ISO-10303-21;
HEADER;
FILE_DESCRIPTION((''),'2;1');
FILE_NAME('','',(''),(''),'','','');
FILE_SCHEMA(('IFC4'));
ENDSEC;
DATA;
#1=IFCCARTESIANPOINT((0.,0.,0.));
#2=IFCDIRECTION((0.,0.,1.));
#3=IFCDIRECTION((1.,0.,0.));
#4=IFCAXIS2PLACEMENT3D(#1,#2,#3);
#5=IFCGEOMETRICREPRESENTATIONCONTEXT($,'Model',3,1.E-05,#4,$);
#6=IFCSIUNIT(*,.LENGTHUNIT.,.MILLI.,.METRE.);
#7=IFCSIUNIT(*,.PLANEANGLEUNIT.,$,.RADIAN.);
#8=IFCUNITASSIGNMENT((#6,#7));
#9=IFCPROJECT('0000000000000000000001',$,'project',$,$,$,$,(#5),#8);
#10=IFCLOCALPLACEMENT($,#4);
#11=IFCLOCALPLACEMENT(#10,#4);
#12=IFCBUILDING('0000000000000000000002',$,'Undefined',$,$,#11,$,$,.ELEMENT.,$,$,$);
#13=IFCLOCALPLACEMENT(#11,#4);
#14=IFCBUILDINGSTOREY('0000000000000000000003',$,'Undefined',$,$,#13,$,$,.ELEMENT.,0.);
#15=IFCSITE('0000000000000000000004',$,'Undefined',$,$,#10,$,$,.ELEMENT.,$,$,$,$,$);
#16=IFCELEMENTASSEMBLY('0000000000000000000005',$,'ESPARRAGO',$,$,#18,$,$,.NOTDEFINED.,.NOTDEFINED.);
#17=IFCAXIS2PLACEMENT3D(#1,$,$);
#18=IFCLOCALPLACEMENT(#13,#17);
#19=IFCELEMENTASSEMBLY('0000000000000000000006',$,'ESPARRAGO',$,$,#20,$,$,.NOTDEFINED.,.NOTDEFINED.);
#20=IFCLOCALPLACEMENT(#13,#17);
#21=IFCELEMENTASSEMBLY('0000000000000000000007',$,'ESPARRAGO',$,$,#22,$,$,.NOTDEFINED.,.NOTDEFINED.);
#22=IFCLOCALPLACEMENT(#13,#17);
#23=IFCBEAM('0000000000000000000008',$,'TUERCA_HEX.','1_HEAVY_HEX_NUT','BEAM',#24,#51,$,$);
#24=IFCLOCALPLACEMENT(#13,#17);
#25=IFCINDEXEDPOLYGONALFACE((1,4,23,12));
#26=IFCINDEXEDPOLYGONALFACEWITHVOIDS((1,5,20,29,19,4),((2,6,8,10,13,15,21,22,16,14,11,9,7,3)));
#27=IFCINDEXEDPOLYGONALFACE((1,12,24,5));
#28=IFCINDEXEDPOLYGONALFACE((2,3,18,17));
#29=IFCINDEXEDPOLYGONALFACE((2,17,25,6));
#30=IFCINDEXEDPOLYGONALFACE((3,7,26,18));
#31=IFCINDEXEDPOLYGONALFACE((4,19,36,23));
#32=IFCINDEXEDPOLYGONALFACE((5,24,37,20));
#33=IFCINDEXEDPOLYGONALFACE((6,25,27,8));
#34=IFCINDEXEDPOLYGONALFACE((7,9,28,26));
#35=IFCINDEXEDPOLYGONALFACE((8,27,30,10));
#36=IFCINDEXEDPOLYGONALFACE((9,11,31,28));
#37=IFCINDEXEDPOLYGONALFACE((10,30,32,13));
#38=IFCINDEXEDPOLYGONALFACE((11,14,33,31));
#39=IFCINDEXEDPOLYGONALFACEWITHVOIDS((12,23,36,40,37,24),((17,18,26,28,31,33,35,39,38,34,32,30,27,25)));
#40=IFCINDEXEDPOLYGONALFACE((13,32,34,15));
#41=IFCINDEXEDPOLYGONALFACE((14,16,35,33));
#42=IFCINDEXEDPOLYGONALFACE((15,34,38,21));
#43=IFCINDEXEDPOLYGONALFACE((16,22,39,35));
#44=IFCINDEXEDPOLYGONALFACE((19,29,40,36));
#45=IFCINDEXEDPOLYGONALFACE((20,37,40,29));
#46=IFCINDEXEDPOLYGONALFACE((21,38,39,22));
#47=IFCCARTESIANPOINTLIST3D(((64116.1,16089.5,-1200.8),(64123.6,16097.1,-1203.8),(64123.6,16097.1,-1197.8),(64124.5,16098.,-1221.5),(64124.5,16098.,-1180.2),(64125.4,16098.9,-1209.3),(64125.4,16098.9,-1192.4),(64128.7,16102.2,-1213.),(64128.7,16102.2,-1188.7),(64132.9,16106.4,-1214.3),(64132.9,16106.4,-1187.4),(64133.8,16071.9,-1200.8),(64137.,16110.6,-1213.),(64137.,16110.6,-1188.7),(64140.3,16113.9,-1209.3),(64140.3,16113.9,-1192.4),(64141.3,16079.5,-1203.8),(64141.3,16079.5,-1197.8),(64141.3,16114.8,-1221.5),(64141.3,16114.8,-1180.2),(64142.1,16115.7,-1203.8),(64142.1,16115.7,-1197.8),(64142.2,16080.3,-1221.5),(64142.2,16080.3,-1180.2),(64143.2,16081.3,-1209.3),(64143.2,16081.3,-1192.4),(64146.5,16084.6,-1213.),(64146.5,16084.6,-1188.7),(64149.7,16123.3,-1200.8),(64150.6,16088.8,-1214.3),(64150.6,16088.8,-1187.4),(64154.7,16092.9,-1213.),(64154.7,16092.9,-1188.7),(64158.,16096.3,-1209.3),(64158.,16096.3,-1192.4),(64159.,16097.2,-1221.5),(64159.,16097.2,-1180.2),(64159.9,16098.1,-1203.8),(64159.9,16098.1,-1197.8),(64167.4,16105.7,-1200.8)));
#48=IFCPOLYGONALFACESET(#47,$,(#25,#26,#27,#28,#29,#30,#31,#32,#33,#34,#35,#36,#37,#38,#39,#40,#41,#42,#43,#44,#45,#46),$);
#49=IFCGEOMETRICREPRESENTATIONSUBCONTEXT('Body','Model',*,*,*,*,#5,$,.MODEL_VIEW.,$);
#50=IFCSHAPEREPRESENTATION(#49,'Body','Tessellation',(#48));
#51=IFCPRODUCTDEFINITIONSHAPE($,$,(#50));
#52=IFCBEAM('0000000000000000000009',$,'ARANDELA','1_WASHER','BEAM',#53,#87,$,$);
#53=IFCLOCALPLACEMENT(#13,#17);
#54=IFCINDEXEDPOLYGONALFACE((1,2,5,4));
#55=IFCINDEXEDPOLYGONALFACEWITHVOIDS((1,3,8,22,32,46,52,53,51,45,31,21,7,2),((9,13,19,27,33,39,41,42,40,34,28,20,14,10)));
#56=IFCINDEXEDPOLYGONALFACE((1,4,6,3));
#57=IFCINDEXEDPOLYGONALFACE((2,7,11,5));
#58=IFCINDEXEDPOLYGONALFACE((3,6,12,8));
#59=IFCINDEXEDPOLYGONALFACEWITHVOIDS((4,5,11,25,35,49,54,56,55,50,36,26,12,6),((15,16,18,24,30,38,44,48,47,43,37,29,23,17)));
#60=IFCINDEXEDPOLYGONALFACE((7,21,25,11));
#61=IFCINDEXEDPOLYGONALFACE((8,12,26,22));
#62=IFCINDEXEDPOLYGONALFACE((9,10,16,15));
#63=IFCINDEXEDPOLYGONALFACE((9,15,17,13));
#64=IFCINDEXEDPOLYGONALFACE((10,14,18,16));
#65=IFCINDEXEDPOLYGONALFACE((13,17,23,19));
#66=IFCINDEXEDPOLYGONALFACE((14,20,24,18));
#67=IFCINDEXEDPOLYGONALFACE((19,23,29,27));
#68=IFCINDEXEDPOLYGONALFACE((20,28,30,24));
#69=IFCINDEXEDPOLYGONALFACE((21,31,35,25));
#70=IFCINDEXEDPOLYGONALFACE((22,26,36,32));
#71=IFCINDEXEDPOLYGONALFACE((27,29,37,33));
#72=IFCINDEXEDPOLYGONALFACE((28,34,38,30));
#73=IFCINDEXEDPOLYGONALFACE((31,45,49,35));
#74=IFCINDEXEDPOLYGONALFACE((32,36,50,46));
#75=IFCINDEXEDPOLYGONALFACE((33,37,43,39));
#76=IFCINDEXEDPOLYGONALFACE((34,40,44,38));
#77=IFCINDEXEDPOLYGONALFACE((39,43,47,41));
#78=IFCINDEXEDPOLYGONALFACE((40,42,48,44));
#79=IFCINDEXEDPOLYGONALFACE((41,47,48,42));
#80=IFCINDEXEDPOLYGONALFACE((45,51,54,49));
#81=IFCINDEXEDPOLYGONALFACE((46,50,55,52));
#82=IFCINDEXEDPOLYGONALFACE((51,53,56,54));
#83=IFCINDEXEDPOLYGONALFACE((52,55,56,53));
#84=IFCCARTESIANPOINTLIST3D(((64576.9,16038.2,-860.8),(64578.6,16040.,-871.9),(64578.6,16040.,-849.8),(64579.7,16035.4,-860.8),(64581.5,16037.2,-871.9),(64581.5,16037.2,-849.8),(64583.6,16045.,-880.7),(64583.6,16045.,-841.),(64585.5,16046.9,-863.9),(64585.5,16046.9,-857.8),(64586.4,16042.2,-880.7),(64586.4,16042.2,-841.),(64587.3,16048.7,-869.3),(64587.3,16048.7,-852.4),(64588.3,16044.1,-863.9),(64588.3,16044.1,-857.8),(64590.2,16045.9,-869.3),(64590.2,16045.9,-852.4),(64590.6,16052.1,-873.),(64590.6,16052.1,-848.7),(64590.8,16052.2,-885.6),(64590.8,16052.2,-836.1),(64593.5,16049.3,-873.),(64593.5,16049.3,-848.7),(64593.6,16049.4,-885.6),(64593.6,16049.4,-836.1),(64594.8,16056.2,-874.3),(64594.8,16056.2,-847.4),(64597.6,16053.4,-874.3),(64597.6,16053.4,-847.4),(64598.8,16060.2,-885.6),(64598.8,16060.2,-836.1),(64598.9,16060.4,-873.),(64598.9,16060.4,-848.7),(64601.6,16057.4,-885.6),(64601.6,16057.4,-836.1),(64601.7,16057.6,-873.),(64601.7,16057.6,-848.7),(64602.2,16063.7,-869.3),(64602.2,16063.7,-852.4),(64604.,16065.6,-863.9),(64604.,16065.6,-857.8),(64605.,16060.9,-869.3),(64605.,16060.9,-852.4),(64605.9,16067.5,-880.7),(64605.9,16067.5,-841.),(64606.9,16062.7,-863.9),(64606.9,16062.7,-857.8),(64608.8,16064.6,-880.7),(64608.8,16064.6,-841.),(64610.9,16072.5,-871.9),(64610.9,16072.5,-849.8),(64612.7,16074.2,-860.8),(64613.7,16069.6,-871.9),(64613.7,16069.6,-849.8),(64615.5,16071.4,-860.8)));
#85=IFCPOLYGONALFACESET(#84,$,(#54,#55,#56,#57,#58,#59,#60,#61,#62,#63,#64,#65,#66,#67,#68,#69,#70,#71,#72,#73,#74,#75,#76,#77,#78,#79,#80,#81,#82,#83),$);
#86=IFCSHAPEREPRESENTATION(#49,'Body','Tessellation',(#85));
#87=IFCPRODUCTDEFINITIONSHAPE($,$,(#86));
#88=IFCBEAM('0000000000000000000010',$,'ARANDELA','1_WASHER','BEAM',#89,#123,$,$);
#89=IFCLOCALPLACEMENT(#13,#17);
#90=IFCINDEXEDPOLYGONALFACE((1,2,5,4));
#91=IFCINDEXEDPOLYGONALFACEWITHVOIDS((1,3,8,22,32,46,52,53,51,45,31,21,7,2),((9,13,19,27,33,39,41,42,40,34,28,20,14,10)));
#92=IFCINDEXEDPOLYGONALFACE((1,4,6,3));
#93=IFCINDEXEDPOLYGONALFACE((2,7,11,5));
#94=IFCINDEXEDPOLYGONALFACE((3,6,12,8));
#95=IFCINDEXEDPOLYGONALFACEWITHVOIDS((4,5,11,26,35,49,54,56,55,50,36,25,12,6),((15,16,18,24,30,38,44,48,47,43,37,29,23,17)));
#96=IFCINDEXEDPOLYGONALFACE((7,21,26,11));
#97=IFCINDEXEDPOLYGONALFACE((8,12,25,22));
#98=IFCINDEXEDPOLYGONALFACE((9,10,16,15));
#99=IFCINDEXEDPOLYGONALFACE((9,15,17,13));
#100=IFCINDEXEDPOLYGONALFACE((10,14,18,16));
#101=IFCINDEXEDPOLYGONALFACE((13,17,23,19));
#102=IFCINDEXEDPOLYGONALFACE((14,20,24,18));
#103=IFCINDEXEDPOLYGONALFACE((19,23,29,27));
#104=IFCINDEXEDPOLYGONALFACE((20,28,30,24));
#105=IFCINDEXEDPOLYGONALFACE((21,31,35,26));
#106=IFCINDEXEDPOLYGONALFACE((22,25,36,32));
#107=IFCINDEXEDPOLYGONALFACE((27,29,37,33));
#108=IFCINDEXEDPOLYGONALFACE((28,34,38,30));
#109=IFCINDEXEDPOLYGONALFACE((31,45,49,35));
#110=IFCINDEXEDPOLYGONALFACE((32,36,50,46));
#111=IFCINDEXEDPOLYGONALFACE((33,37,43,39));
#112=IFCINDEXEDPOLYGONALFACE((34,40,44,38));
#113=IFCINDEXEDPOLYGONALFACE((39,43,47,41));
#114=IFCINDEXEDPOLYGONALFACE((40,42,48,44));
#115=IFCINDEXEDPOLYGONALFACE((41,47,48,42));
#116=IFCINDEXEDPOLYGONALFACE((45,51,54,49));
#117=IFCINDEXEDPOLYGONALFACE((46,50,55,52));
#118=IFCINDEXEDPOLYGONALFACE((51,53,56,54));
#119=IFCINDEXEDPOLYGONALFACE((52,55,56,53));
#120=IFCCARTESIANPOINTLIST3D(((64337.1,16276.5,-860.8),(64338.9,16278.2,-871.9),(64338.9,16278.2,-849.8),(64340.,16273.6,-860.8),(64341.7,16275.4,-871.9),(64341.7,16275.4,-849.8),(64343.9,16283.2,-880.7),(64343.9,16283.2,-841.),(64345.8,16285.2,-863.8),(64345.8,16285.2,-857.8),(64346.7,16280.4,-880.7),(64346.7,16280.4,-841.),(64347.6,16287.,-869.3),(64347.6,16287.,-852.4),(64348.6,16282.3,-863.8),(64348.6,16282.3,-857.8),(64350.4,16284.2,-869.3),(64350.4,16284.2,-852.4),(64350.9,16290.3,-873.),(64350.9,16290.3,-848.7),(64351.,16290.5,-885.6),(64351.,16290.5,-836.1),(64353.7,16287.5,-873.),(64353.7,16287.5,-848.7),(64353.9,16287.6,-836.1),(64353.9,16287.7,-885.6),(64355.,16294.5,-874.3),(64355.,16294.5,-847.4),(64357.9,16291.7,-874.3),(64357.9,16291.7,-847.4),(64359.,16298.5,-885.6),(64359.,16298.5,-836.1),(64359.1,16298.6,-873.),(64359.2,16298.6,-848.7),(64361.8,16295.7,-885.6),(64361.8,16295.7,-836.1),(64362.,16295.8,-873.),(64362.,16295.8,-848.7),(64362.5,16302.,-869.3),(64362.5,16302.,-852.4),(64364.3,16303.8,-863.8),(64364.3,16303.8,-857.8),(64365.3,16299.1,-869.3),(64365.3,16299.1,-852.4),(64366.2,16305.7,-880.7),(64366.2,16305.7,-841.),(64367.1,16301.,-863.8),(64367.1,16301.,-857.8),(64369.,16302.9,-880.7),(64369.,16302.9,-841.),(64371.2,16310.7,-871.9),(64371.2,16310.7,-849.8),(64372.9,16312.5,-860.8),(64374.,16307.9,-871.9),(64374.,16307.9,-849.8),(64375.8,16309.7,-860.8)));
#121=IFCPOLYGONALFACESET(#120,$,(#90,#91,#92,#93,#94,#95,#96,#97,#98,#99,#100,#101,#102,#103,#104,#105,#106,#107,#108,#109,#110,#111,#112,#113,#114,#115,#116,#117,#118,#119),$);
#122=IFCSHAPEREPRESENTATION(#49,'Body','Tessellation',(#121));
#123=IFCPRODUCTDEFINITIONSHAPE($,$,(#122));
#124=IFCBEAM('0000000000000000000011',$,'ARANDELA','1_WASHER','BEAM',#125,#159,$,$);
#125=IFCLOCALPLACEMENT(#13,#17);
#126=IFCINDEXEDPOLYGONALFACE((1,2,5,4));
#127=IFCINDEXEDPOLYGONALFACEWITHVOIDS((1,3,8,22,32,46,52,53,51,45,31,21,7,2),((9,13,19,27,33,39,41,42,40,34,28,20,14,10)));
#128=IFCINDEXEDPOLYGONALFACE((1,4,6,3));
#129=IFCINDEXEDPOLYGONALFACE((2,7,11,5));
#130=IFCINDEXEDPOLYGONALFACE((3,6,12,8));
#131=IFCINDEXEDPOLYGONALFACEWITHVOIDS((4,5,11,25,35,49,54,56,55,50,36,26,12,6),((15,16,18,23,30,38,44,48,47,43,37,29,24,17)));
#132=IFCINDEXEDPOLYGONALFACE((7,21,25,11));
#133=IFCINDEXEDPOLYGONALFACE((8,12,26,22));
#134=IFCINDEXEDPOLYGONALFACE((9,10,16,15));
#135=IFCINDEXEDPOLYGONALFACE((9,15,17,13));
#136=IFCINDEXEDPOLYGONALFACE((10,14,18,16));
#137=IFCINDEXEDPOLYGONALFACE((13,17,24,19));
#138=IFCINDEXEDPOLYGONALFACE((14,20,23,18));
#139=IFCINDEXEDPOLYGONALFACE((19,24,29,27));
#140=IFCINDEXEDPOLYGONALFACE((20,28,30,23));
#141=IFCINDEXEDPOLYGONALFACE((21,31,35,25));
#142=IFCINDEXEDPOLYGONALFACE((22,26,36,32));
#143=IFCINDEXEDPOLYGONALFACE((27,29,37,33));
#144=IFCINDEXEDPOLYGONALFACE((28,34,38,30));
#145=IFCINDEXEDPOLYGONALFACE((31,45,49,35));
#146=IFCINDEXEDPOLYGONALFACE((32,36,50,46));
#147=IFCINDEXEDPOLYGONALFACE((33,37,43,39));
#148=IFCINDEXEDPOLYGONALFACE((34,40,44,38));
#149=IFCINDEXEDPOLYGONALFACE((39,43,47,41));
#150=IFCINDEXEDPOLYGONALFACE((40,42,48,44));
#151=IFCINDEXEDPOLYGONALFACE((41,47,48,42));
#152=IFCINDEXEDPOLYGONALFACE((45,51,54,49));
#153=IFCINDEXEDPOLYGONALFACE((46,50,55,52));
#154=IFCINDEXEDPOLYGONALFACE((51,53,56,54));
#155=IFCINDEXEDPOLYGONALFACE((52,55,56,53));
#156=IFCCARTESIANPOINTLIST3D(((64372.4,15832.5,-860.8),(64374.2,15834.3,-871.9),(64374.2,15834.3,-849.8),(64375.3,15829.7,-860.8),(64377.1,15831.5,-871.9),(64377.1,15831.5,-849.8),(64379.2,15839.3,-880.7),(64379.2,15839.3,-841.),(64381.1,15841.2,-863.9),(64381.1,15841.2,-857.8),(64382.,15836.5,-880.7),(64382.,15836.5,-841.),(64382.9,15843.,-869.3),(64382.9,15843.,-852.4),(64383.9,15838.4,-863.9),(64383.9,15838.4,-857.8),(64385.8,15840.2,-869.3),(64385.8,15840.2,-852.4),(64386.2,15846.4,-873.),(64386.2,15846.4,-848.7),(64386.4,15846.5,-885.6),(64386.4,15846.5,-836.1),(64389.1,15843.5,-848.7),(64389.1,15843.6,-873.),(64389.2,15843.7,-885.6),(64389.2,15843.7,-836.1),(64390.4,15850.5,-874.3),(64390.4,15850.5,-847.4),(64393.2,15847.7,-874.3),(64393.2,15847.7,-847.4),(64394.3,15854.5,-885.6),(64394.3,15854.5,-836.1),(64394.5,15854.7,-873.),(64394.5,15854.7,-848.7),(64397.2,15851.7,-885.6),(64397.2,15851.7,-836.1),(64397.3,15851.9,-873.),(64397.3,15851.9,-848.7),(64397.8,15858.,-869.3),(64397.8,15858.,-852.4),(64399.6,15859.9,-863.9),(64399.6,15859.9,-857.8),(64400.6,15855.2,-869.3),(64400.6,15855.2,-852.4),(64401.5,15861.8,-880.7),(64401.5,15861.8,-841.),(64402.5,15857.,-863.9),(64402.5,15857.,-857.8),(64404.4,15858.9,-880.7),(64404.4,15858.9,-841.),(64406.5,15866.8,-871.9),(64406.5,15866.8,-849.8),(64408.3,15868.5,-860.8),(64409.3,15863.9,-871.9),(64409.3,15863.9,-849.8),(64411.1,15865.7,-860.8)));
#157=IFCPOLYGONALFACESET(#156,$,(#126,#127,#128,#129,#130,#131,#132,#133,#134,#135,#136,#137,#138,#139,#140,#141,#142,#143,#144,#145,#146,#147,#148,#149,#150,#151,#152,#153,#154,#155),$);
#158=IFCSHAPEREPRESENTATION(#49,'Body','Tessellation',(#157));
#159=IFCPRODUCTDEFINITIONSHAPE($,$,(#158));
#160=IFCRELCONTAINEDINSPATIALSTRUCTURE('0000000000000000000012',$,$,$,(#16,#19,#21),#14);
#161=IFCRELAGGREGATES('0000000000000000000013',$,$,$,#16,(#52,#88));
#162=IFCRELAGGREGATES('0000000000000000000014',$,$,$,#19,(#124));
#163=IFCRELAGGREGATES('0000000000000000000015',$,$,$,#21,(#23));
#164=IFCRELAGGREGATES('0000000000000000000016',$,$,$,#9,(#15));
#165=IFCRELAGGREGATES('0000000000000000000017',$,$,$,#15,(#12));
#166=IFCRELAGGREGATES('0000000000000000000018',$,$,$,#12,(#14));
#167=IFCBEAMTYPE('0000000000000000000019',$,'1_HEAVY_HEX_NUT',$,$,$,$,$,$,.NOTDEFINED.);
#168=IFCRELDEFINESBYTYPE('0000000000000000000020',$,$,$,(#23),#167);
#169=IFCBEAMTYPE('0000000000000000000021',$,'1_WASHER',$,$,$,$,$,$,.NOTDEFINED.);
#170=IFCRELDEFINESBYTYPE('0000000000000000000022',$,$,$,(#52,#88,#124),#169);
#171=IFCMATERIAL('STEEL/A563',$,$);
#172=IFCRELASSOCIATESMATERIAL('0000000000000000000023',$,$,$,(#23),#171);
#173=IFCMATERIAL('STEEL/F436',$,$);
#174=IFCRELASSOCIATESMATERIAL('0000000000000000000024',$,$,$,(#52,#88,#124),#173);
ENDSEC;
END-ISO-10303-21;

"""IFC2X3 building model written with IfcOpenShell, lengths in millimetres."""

from ifc_helpers import new_model, si_unit, frame, origin_with_axes, place, context, subcontext, project, spatial, polyline, outline, extrude, material, type_object, element, aggregate, save


model = new_model("IFC2X3")

# Units and contexts
model_context = context("Model", 3, precision=1e-05, world=origin_with_axes())
body_context = subcontext(model_context, "Body", "Model", "MODEL_VIEW")
ifc_project = project(units=[si_unit("LENGTHUNIT", "METRE", prefix="MILLI"), si_unit("PLANEANGLEUNIT", "RADIAN")], contexts=[model_context])

# Site, building, storey
site_placement = place(None, origin_with_axes())
site = spatial("IfcSite", under=ifc_project, at=site_placement, Name="Undefined", CompositionType="ELEMENT")
building_placement = place(site_placement, origin_with_axes())
building = spatial("IfcBuilding", under=site, at=building_placement, Name="Undefined", CompositionType="ELEMENT")
storey_placement = place(building_placement, origin_with_axes())
storey = spatial("IfcBuildingStorey", under=building, at=storey_placement, Name="Undefined", CompositionType="ELEMENT", Elevation=0.0)

# Element assemblies
assembly_1_placement = place(storey_placement, origin_with_axes())
assembly_1 = element("IfcElementAssembly", 1, at=assembly_1_placement, inside=storey, Name="ESPARRAGO", AssemblyPlace="NOTDEFINED", PredefinedType="NOTDEFINED")
ifc_material_1 = material(Name="STEEL/A563")
beam_type_1 = type_object("IfcBeamType", Name="1_HEAVY_HEX_NUT", PredefinedType="NOTDEFINED")
assembly_2_placement = place(storey_placement, origin_with_axes())
assembly_2 = element("IfcElementAssembly", 2, at=assembly_2_placement, inside=storey, Name="ESPARRAGO", AssemblyPlace="NOTDEFINED", PredefinedType="NOTDEFINED")

# Element assembly, beam
assembly_3_placement = place(storey_placement, origin_with_axes())
assembly_3 = element("IfcElementAssembly", 3, at=assembly_3_placement, inside=storey, Name="ESPARRAGO", AssemblyPlace="NOTDEFINED", PredefinedType="NOTDEFINED")
beam_1_placement = place(assembly_3_placement, frame((64132.9, 16106.4, -1200.8), z_axis=(0.00001, -0.00001, 1.0), x_axis=(0.709311, -0.704895, -0.000014)))
beam_1 = element("IfcBeam", 4, at=beam_1_placement, type_object=beam_type_1, material=ifc_material_1, Name="TUERCA_HEX.", Description="1_HEAVY_HEX_NUT", ObjectType="BEAM", context=body_context, shape_type="SweptSolid", body=[
    extrude(outline(polyline([(11.9, -20.6), (-11.9, -20.6), (-23.8, 0.0), (-11.9, 20.6), (11.9, 20.6), (23.8, 0.0), (11.9, -20.6)]), holes=[polyline([(-5.9, 12.2), (-10.5, 8.4), (-13.2, 3.0), (-13.2, -3.0), (-10.5, -8.4), (-5.9, -12.2), (0.0, -13.5), (5.9, -12.2), (10.5, -8.4), (13.2, -3.0), (13.2, 3.0), (10.5, 8.4), (5.9, 12.2), (0.0, 13.5), (-5.9, 12.2)])]), frame((25.0, 0.0, 0.0), z_axis=(-1.0, 0.0, 0.0), x_axis=(0.0, -1.0, 0.0)), (0.0, 0.0, 1.0), 25.0),
])

# Beams
ifc_material_2 = material(Name="STEEL/F436")
beam_type_2 = type_object("IfcBeamType", Name="1_WASHER", PredefinedType="NOTDEFINED")
beam_2_placement = place(assembly_1_placement, frame((64594.8, 16056.2, -860.8), z_axis=(0.000061, -0.000061, 1.0), x_axis=(0.709311, -0.704895, -0.000086)))
beam_2 = element("IfcBeam", 5, at=beam_2_placement, type_object=beam_type_2, material=ifc_material_2, Name="ARANDELA", Description="1_WASHER", ObjectType="BEAM", context=body_context, shape_type="SweptSolid", body=[
    extrude(outline(polyline([(-15.8, -19.9), (-22.9, -11.0), (-25.4, 0.0), (-22.9, 11.0), (-15.8, 19.9), (-5.7, 24.8), (5.7, 24.8), (15.8, 19.9), (22.9, 11.0), (25.4, 0.0), (22.9, -11.0), (15.8, -19.9), (5.7, -24.8), (-5.7, -24.8), (-15.8, -19.9)]), holes=[polyline([(-5.9, 12.2), (-10.5, 8.4), (-13.2, 3.0), (-13.2, -3.0), (-10.5, -8.4), (-5.9, -12.2), (0.0, -13.5), (5.9, -12.2), (10.5, -8.4), (13.2, -3.0), (13.2, 3.0), (10.5, 8.4), (5.9, 12.2), (0.0, 13.5), (-5.9, 12.2)])]), frame((4.0, 0.0, 0.0), z_axis=(-1.0, 0.0, 0.0), x_axis=(0.0, -1.0, 0.0)), (0.0, 0.0, 1.0), 4.0),
])
beam_3_placement = place(assembly_1_placement, frame((64355.0, 16294.5, -860.8), z_axis=(0.000061, -0.000061, 1.0), x_axis=(0.709311, -0.704895, -0.000086)))
beam_3 = element("IfcBeam", 6, at=beam_3_placement, type_object=beam_type_2, material=ifc_material_2, Name="ARANDELA", Description="1_WASHER", ObjectType="BEAM", context=body_context, shape_type="SweptSolid", body=[
    extrude(outline(polyline([(-15.8, -19.9), (-22.9, -11.0), (-25.4, 0.0), (-22.9, 11.0), (-15.8, 19.9), (-5.7, 24.8), (5.7, 24.8), (15.8, 19.9), (22.9, 11.0), (25.4, 0.0), (22.9, -11.0), (15.8, -19.9), (5.7, -24.8), (-5.7, -24.8), (-15.8, -19.9)]), holes=[polyline([(-5.9, 12.2), (-10.5, 8.4), (-13.2, 3.0), (-13.2, -3.0), (-10.5, -8.4), (-5.9, -12.2), (0.0, -13.5), (5.9, -12.2), (10.5, -8.4), (13.2, -3.0), (13.2, 3.0), (10.5, 8.4), (5.9, 12.2), (0.0, 13.5), (-5.9, 12.2)])]), frame((4.0, 0.0, 0.0), z_axis=(-1.0, 0.0, 0.0), x_axis=(0.0, -1.0, 0.0)), (0.0, 0.0, 1.0), 4.0),
])
beam_4_placement = place(assembly_2_placement, frame((64390.4, 15850.5, -860.8), z_axis=(0.000061, -0.000061, 1.0), x_axis=(0.709311, -0.704895, -0.000086)))
beam_4 = element("IfcBeam", 7, at=beam_4_placement, type_object=beam_type_2, material=ifc_material_2, Name="ARANDELA", Description="1_WASHER", ObjectType="BEAM", context=body_context, shape_type="SweptSolid", body=[
    extrude(outline(polyline([(-15.8, -19.9), (-22.9, -11.0), (-25.4, 0.0), (-22.9, 11.0), (-15.8, 19.9), (-5.7, 24.8), (5.7, 24.8), (15.8, 19.9), (22.9, 11.0), (25.4, 0.0), (22.9, -11.0), (15.8, -19.9), (5.7, -24.8), (-5.7, -24.8), (-15.8, -19.9)]), holes=[polyline([(-5.9, 12.2), (-10.5, 8.4), (-13.2, 3.0), (-13.2, -3.0), (-10.5, -8.4), (-5.9, -12.2), (0.0, -13.5), (5.9, -12.2), (10.5, -8.4), (13.2, -3.0), (13.2, 3.0), (10.5, 8.4), (5.9, 12.2), (0.0, 13.5), (-5.9, 12.2)])]), frame((4.0, 0.0, 0.0), z_axis=(-1.0, 0.0, 0.0), x_axis=(0.0, -1.0, 0.0)), (0.0, 0.0, 1.0), 4.0),
])
aggregate(assembly_1, [beam_2, beam_3])
aggregate(assembly_2, [beam_4])
aggregate(assembly_3, [beam_1])

save(model, "model.ifc")
